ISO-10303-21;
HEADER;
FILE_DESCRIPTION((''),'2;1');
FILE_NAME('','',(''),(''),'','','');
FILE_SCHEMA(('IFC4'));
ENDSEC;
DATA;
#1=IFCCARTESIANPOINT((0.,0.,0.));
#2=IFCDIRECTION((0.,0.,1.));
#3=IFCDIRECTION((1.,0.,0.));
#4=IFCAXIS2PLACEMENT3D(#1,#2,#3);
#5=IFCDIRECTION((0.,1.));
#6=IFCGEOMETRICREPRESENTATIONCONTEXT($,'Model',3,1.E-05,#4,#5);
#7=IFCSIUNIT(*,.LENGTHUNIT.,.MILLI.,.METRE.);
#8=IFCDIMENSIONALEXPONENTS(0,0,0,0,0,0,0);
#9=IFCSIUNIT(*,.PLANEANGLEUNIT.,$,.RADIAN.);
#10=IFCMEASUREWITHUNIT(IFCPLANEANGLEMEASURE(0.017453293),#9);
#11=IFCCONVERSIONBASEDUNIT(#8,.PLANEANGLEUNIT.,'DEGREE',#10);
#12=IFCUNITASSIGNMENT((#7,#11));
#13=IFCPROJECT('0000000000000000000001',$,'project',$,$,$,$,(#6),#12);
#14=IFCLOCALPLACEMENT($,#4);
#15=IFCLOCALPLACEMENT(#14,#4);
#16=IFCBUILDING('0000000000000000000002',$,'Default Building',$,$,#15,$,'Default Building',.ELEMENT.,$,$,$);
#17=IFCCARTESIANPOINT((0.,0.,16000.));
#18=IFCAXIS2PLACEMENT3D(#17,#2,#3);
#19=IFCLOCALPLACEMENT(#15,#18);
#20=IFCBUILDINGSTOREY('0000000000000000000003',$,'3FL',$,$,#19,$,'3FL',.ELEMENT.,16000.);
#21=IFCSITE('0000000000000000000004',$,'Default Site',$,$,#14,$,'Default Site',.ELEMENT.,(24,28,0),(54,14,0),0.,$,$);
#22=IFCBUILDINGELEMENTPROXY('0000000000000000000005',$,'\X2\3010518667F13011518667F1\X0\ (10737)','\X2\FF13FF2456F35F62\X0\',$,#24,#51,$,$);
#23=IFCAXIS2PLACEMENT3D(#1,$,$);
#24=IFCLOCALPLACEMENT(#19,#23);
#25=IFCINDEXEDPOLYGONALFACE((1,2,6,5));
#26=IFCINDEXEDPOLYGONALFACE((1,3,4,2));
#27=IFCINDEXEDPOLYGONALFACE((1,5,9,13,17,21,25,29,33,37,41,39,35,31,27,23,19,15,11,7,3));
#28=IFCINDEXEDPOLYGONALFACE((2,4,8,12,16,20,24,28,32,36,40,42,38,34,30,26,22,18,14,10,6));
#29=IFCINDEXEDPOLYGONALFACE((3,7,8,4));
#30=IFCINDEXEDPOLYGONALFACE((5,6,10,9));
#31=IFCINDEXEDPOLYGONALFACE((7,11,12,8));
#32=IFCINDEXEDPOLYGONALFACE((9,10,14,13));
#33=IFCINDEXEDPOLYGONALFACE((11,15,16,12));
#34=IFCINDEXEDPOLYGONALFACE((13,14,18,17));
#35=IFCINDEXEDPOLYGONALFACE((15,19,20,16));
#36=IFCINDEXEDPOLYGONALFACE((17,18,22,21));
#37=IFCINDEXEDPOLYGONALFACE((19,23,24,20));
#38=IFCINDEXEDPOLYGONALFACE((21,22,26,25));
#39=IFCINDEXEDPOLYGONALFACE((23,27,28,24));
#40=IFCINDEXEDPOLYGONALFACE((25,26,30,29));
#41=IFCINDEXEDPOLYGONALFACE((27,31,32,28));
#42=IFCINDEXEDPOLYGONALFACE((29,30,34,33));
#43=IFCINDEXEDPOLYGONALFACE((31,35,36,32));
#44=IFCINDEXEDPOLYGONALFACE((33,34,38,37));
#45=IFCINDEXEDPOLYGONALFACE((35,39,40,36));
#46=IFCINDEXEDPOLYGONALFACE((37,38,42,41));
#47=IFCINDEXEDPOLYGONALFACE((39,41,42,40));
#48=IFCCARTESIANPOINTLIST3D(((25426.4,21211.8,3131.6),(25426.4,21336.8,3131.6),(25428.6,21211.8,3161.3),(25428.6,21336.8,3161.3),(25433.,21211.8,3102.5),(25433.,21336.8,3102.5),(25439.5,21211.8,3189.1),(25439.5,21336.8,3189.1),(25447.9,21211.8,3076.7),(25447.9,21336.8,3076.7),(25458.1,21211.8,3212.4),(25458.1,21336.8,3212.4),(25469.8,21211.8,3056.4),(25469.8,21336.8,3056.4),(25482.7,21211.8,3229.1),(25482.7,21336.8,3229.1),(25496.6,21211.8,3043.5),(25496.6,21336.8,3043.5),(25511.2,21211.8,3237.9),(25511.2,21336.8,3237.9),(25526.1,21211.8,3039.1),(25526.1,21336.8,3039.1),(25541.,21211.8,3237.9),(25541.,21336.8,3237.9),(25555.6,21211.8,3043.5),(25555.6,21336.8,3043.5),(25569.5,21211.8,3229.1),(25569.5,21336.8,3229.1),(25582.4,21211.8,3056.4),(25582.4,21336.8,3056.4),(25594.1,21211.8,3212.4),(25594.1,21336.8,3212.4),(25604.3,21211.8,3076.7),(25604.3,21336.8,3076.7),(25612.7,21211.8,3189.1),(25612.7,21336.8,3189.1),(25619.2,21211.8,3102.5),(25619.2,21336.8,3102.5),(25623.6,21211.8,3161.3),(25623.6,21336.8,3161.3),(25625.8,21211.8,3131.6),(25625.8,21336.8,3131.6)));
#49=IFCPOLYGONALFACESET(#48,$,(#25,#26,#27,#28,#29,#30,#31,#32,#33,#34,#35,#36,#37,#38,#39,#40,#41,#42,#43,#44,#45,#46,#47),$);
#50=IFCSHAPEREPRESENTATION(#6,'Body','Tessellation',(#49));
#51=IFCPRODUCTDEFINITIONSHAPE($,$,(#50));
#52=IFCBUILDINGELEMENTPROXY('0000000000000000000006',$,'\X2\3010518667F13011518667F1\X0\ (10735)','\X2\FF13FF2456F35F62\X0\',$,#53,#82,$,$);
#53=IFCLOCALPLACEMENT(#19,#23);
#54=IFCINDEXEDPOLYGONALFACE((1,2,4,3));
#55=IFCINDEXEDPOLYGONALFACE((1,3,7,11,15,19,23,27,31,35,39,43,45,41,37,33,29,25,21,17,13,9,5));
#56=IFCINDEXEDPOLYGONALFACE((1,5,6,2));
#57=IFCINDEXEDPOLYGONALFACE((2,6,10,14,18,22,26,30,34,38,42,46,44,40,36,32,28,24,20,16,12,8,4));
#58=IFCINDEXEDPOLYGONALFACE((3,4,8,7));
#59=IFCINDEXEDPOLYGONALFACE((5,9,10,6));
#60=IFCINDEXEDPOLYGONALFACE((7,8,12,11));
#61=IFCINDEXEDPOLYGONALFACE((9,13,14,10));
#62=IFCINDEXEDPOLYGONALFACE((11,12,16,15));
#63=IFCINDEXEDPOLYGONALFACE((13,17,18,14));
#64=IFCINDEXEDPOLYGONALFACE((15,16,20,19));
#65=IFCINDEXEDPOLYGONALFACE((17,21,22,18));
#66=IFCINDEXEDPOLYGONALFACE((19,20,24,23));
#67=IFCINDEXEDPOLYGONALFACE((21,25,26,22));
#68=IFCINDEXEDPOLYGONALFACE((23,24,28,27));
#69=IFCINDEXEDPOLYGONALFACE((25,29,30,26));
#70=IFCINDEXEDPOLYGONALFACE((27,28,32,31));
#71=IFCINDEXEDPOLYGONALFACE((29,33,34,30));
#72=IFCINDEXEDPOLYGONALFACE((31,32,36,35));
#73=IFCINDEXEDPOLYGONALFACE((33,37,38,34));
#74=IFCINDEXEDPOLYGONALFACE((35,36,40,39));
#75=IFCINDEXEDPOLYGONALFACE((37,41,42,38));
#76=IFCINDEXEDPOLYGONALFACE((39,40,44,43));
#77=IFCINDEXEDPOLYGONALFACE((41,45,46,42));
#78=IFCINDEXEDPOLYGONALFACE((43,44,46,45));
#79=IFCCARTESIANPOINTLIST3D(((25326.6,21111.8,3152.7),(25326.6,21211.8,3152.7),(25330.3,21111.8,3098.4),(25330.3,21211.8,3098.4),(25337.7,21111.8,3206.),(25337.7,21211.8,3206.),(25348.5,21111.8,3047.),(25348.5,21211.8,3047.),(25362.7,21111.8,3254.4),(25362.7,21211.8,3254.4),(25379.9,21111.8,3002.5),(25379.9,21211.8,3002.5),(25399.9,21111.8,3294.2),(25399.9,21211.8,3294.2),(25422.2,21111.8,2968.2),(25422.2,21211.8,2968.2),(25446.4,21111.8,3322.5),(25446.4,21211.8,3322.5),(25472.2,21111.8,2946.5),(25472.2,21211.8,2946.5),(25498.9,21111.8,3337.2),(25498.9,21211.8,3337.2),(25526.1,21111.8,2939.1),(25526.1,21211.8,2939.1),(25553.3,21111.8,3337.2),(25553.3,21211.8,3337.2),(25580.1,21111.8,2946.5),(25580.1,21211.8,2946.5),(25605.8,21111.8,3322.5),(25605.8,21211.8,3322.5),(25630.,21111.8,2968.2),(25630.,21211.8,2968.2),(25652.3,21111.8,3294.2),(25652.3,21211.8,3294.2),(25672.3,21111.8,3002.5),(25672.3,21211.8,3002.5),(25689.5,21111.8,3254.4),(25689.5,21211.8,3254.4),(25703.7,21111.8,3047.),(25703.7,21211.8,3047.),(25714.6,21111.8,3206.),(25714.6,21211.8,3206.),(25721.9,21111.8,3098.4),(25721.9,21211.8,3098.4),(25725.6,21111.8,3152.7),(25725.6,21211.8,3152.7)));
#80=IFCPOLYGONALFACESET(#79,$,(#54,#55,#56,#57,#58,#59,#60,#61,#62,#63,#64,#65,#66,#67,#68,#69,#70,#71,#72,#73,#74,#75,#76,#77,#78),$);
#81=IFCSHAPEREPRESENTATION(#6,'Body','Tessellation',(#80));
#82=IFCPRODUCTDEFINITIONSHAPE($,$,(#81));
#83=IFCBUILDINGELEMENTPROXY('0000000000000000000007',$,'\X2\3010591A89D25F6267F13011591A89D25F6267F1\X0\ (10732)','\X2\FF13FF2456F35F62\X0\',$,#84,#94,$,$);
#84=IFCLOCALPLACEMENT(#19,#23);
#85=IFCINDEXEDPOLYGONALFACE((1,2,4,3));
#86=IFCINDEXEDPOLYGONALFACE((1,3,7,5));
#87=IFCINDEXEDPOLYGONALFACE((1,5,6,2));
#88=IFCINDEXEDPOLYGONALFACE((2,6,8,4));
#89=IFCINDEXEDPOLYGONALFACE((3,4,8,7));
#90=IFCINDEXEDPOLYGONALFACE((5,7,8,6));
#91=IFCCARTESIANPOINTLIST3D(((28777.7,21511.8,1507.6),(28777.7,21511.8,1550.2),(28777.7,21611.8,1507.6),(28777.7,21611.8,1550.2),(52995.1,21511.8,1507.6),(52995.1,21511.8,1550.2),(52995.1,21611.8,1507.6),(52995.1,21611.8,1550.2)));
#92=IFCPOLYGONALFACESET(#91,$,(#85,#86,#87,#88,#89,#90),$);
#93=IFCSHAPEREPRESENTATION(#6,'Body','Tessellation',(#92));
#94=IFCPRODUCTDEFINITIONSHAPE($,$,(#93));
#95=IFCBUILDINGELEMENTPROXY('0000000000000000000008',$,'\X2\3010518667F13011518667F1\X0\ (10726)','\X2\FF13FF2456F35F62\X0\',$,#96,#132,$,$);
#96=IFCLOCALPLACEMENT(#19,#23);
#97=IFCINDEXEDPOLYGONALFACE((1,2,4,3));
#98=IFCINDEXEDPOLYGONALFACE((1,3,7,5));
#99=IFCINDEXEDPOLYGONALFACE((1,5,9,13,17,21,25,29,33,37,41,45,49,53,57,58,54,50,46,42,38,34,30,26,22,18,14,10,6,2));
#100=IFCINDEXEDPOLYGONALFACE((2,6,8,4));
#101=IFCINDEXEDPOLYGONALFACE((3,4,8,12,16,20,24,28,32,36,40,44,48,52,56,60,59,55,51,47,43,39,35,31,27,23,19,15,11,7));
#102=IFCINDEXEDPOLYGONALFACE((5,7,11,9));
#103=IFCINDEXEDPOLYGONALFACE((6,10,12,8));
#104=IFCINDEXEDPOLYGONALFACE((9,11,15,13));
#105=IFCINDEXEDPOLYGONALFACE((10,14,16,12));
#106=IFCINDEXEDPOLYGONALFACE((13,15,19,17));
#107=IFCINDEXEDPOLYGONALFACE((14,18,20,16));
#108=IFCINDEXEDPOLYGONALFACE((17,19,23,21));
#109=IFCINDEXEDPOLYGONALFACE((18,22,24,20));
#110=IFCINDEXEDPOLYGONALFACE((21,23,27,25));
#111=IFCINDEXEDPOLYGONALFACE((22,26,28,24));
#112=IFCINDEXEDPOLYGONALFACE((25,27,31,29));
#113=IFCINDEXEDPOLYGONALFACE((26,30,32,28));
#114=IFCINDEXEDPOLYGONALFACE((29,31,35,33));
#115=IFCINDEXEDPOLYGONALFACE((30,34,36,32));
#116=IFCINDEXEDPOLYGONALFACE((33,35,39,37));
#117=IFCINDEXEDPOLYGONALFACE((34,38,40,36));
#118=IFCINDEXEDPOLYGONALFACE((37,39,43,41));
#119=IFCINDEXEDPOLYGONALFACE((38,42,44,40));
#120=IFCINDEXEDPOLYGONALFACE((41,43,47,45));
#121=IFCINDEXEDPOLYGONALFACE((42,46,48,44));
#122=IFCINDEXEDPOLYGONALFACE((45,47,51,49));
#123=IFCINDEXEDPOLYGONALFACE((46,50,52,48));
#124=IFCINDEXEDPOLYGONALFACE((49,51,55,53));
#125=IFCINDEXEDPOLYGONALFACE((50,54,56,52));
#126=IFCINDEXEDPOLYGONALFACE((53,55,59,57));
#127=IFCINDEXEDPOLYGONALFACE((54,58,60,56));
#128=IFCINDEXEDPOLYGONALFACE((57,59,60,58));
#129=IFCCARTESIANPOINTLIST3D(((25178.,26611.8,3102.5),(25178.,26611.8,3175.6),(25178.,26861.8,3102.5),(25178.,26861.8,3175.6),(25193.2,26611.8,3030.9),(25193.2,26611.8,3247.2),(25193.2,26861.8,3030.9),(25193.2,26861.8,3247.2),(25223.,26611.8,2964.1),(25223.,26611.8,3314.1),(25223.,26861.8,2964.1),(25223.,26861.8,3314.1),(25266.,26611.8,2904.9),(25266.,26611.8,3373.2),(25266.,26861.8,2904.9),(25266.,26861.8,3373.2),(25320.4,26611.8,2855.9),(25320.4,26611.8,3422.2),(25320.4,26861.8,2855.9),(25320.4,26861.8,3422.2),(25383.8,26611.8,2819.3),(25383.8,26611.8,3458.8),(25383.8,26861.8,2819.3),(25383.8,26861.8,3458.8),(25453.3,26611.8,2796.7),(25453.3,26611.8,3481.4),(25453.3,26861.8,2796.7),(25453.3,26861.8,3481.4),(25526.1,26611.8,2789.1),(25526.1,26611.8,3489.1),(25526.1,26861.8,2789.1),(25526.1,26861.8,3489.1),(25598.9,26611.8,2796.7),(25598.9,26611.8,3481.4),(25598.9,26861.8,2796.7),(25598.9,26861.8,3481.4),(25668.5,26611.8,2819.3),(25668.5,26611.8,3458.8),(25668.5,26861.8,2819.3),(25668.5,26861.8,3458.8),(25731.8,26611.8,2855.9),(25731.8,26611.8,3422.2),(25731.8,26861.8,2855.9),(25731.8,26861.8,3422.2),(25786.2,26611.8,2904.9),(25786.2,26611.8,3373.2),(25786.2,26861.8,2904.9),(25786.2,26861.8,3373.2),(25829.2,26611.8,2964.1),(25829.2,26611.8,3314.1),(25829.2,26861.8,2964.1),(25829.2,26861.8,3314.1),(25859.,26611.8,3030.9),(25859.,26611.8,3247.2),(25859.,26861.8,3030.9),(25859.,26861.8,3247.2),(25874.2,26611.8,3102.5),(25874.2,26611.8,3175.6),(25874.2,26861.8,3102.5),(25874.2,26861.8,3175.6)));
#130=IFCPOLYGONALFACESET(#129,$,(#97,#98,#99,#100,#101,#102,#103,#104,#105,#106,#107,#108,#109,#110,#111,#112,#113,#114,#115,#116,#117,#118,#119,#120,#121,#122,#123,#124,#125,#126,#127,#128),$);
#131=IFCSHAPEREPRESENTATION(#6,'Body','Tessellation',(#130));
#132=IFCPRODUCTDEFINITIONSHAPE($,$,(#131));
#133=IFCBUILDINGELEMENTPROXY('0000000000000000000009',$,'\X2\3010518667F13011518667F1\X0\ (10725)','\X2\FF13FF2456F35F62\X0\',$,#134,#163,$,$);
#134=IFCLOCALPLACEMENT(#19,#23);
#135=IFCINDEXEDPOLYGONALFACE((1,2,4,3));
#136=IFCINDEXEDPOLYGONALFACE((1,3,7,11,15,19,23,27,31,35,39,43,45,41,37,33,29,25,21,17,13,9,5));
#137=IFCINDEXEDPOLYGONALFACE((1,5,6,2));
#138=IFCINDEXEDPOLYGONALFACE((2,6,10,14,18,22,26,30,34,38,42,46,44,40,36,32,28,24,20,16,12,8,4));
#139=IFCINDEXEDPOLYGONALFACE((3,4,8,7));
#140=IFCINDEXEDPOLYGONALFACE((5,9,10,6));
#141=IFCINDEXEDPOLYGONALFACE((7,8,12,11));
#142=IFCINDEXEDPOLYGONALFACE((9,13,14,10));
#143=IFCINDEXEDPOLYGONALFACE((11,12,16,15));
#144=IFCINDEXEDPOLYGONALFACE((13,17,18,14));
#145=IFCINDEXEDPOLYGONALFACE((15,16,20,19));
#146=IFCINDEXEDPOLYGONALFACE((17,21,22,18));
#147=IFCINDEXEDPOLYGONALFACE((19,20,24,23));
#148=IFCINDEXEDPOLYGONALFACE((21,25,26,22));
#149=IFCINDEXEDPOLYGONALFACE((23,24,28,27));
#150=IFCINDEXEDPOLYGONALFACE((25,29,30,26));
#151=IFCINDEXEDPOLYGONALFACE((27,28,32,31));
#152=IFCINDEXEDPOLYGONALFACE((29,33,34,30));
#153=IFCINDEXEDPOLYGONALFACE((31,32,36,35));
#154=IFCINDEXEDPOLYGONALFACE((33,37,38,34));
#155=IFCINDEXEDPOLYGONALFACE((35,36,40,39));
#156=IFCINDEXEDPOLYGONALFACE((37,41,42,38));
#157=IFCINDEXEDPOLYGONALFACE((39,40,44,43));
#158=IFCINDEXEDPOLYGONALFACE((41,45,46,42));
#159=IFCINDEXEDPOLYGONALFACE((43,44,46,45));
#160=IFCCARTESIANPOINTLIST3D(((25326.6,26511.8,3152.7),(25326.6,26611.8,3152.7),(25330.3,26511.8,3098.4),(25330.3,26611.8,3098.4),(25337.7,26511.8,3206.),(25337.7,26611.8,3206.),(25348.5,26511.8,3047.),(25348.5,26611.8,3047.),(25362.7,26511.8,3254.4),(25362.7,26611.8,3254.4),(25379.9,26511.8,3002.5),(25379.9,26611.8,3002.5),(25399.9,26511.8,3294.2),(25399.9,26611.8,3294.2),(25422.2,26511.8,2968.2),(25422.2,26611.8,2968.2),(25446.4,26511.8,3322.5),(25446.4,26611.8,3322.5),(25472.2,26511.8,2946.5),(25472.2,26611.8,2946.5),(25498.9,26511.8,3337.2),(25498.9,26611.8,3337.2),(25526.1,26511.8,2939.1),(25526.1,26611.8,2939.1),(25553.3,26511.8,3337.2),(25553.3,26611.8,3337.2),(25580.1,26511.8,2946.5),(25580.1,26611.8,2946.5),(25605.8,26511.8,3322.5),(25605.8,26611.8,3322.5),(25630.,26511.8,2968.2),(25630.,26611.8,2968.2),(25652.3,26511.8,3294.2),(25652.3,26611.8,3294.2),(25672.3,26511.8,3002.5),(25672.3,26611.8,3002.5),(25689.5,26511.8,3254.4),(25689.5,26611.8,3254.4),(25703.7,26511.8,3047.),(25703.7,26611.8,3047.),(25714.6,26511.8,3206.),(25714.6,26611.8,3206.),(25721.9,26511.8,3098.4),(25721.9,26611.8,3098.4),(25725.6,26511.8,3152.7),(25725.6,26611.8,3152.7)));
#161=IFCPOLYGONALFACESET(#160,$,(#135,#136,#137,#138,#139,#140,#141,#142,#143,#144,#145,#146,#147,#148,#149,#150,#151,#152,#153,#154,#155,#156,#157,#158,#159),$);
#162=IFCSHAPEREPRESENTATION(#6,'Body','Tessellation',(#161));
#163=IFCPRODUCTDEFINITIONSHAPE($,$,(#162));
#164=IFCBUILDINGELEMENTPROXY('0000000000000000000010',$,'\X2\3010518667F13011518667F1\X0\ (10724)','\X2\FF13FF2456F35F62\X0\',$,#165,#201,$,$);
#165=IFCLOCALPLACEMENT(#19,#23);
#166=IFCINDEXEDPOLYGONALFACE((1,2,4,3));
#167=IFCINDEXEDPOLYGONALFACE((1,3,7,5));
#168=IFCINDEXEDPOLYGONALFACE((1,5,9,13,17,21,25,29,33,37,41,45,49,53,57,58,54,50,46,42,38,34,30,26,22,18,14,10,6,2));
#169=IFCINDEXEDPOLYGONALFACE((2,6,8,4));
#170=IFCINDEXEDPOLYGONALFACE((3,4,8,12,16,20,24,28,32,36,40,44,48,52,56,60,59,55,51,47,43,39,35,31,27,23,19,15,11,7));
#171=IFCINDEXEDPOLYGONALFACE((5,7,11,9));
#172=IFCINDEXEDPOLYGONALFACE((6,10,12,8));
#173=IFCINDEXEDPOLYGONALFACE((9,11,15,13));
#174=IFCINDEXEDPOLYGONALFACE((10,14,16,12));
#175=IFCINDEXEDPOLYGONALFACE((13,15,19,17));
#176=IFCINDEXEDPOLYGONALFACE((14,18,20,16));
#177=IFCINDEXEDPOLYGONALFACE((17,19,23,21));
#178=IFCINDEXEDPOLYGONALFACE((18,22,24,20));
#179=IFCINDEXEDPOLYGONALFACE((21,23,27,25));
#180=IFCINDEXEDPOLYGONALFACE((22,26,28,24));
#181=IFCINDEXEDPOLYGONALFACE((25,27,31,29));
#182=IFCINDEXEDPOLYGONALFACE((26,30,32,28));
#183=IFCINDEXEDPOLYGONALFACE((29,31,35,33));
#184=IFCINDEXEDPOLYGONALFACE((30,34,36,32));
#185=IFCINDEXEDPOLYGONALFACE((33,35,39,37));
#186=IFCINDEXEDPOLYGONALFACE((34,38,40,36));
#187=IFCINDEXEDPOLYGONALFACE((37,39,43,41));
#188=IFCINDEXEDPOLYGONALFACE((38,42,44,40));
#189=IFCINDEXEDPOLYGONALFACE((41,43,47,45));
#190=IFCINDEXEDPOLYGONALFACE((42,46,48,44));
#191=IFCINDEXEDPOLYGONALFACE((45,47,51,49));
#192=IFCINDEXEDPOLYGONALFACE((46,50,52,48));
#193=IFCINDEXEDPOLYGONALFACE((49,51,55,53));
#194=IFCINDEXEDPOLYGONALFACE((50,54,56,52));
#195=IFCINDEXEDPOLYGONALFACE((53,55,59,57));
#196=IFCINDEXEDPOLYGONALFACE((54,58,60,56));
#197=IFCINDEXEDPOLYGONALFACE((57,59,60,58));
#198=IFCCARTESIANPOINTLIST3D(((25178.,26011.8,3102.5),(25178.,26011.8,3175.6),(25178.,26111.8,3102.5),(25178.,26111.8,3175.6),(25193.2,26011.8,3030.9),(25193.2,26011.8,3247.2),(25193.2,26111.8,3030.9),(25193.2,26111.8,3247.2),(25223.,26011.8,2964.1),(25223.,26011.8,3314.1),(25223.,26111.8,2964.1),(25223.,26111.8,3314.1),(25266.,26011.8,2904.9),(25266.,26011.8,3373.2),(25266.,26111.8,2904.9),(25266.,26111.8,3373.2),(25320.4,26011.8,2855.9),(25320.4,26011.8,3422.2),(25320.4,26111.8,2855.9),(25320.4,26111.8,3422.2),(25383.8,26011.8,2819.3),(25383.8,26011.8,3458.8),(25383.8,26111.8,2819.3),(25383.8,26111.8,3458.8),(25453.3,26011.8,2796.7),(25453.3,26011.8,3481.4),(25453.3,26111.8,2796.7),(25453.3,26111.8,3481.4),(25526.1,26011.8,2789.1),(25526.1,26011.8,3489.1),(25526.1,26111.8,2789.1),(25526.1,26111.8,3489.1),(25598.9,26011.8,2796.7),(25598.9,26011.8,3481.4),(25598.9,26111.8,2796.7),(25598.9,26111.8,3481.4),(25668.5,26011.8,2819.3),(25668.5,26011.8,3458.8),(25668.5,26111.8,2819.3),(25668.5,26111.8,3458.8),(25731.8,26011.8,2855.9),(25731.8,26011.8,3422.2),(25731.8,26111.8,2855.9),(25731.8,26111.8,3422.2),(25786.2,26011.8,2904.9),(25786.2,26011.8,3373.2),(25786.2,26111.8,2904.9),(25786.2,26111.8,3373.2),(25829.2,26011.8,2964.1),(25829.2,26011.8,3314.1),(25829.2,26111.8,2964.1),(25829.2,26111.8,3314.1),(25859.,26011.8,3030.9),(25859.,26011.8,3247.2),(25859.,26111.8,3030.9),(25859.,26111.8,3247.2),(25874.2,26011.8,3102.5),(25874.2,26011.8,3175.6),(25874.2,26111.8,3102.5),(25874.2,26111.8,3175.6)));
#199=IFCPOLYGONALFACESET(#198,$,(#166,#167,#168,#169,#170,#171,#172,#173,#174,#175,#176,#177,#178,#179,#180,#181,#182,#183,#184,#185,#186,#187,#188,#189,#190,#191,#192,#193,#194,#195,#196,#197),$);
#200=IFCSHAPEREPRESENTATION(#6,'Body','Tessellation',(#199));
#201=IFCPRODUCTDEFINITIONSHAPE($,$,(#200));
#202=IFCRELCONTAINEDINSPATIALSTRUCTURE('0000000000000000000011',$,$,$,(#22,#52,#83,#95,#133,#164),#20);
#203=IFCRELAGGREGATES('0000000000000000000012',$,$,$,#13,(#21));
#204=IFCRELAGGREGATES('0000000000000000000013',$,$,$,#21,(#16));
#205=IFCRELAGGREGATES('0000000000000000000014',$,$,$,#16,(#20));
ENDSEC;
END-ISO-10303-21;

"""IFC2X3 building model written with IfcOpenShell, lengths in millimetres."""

from ifc_helpers import new_model, entity, si_unit, converted_unit, direction, frame, origin_with_axes, origin_2d_with_axis, place, context, project, spatial, polyline, circle, outline, extrude, source, transform, mapped, element, save


model = new_model("IFC2X3")

# Units and contexts
model_context = context("Model", 3, precision=1e-05, world=origin_with_axes(), true_north=direction((0.0, 1.0)))
ifc_project = project(units=[si_unit("LENGTHUNIT", "METRE", prefix="MILLI"), converted_unit("PLANEANGLEUNIT", "DEGREE", entity("IfcPlaneAngleMeasure", 0.017453293), si_unit("PLANEANGLEUNIT", "RADIAN"), dimensions=[0, 0, 0, 0, 0, 0, 0])], contexts=[model_context])

# Site, building, storey
site_placement = place(None, origin_with_axes())
site = spatial("IfcSite", under=ifc_project, at=site_placement, Name="Default Site", LongName="Default Site", CompositionType="ELEMENT", RefLatitude=(24, 28, 0), RefLongitude=(54, 14, 0), RefElevation=0.0)
building_placement = place(site_placement, origin_with_axes())
building = spatial("IfcBuilding", under=site, at=building_placement, Name="Default Building", LongName="Default Building", CompositionType="ELEMENT")
storey_placement = place(building_placement, frame((0.0, 0.0, 16000.0), z_axis=(0.0, 0.0, 1.0), x_axis=(1.0, 0.0, 0.0)))
storey = spatial("IfcBuildingStorey", under=building, at=storey_placement, Name="3FL", LongName="3FL", CompositionType="ELEMENT", Elevation=16000.0)

# Building element proxies
shared_shape_1 = source(origin_with_axes(), model_context, "Body", "SweptSolid", [
    extrude(circle(Radius=100.0, at=origin_2d_with_axis()), frame((0.0, 0.0, 0.0), z_axis=(0.0, 0.0, 1.0), x_axis=(1.0, 0.0, 0.0)), (0.0, 0.0, 1.0), 125.0),
])
proxy_1_placement = place(storey_placement, frame((25526.1, 21211.8, 3139.1), z_axis=(0.0, 1.0, 0.0), x_axis=(0.0, 0.0, -1.0)))
element("IfcBuildingElementProxy", 1, at=proxy_1_placement, inside=storey, Name="【円柱】円柱 (10737)", Description="３Ｄ図形", context=model_context, shape_type="MappedRepresentation", body=[
    mapped(shared_shape_1, transform((0.0, 0.0, 0.0))),
])
shared_shape_2 = source(origin_with_axes(), model_context, "Body", "SweptSolid", [
    extrude(circle(Radius=200.0, at=origin_2d_with_axis()), frame((0.0, 0.0, 0.0), z_axis=(0.0, 0.0, 1.0), x_axis=(1.0, 0.0, 0.0)), (0.0, 0.0, 1.0), 100.0),
])
proxy_2_placement = place(storey_placement, frame((25526.1, 21111.8, 3139.1), z_axis=(0.0, 1.0, 0.0), x_axis=(0.0, 0.0, -1.0)))
element("IfcBuildingElementProxy", 2, at=proxy_2_placement, inside=storey, Name="【円柱】円柱 (10735)", Description="３Ｄ図形", context=model_context, shape_type="MappedRepresentation", body=[
    mapped(shared_shape_2, transform((0.0, 0.0, 0.0))),
])
shared_shape_3 = source(origin_with_axes(), model_context, "Body", "SweptSolid", [
    extrude(outline(polyline([(-12108.7, -21.3), (12108.7, -21.3), (12108.7, 21.3), (-12108.7, 21.3), (-12108.7, -21.3)])), origin_with_axes(), (0.0, 0.0, 1.0), 100.0),
])
proxy_3_placement = place(storey_placement, frame((40886.4, 21611.8, 1528.9), z_axis=(0.0, -1.0, 0.0), x_axis=(1.0, 0.0, 0.0)))
element("IfcBuildingElementProxy", 3, at=proxy_3_placement, inside=storey, Name="【多角形柱】多角形柱 (10732)", Description="３Ｄ図形", context=model_context, shape_type="MappedRepresentation", body=[
    mapped(shared_shape_3, transform((0.0, 0.0, 0.0))),
])
shared_shape_4 = source(origin_with_axes(), model_context, "Body", "SweptSolid", [
    extrude(circle(Radius=350.0, at=origin_2d_with_axis()), frame((0.0, 0.0, 0.0), z_axis=(0.0, 0.0, 1.0), x_axis=(1.0, 0.0, 0.0)), (0.0, 0.0, 1.0), 250.0),
])
proxy_4_placement = place(storey_placement, frame((25526.1, 26611.8, 3139.1), z_axis=(0.0, 1.0, 0.0), x_axis=(0.0, 0.0, -1.0)))
element("IfcBuildingElementProxy", 4, at=proxy_4_placement, inside=storey, Name="【円柱】円柱 (10726)", Description="３Ｄ図形", context=model_context, shape_type="MappedRepresentation", body=[
    mapped(shared_shape_4, transform((0.0, 0.0, 0.0))),
])
shared_shape_5 = source(origin_with_axes(), model_context, "Body", "SweptSolid", [
    extrude(circle(Radius=200.0, at=origin_2d_with_axis()), frame((0.0, 0.0, 0.0), z_axis=(0.0, 0.0, 1.0), x_axis=(1.0, 0.0, 0.0)), (0.0, 0.0, 1.0), 100.0),
])
proxy_5_placement = place(storey_placement, frame((25526.1, 26511.8, 3139.1), z_axis=(0.0, 1.0, 0.0), x_axis=(0.0, 0.0, -1.0)))
element("IfcBuildingElementProxy", 5, at=proxy_5_placement, inside=storey, Name="【円柱】円柱 (10725)", Description="３Ｄ図形", context=model_context, shape_type="MappedRepresentation", body=[
    mapped(shared_shape_5, transform((0.0, 0.0, 0.0))),
])
shared_shape_6 = source(origin_with_axes(), model_context, "Body", "SweptSolid", [
    extrude(circle(Radius=350.0, at=origin_2d_with_axis()), frame((0.0, 0.0, 0.0), z_axis=(0.0, 0.0, 1.0), x_axis=(1.0, 0.0, 0.0)), (0.0, 0.0, 1.0), 100.0),
])
proxy_6_placement = place(storey_placement, frame((25526.1, 26011.8, 3139.1), z_axis=(0.0, 1.0, 0.0), x_axis=(0.0, 0.0, -1.0)))
element("IfcBuildingElementProxy", 6, at=proxy_6_placement, inside=storey, Name="【円柱】円柱 (10724)", Description="３Ｄ図形", context=model_context, shape_type="MappedRepresentation", body=[
    mapped(shared_shape_6, transform((0.0, 0.0, 0.0))),
])

save(model, "model.ifc")
